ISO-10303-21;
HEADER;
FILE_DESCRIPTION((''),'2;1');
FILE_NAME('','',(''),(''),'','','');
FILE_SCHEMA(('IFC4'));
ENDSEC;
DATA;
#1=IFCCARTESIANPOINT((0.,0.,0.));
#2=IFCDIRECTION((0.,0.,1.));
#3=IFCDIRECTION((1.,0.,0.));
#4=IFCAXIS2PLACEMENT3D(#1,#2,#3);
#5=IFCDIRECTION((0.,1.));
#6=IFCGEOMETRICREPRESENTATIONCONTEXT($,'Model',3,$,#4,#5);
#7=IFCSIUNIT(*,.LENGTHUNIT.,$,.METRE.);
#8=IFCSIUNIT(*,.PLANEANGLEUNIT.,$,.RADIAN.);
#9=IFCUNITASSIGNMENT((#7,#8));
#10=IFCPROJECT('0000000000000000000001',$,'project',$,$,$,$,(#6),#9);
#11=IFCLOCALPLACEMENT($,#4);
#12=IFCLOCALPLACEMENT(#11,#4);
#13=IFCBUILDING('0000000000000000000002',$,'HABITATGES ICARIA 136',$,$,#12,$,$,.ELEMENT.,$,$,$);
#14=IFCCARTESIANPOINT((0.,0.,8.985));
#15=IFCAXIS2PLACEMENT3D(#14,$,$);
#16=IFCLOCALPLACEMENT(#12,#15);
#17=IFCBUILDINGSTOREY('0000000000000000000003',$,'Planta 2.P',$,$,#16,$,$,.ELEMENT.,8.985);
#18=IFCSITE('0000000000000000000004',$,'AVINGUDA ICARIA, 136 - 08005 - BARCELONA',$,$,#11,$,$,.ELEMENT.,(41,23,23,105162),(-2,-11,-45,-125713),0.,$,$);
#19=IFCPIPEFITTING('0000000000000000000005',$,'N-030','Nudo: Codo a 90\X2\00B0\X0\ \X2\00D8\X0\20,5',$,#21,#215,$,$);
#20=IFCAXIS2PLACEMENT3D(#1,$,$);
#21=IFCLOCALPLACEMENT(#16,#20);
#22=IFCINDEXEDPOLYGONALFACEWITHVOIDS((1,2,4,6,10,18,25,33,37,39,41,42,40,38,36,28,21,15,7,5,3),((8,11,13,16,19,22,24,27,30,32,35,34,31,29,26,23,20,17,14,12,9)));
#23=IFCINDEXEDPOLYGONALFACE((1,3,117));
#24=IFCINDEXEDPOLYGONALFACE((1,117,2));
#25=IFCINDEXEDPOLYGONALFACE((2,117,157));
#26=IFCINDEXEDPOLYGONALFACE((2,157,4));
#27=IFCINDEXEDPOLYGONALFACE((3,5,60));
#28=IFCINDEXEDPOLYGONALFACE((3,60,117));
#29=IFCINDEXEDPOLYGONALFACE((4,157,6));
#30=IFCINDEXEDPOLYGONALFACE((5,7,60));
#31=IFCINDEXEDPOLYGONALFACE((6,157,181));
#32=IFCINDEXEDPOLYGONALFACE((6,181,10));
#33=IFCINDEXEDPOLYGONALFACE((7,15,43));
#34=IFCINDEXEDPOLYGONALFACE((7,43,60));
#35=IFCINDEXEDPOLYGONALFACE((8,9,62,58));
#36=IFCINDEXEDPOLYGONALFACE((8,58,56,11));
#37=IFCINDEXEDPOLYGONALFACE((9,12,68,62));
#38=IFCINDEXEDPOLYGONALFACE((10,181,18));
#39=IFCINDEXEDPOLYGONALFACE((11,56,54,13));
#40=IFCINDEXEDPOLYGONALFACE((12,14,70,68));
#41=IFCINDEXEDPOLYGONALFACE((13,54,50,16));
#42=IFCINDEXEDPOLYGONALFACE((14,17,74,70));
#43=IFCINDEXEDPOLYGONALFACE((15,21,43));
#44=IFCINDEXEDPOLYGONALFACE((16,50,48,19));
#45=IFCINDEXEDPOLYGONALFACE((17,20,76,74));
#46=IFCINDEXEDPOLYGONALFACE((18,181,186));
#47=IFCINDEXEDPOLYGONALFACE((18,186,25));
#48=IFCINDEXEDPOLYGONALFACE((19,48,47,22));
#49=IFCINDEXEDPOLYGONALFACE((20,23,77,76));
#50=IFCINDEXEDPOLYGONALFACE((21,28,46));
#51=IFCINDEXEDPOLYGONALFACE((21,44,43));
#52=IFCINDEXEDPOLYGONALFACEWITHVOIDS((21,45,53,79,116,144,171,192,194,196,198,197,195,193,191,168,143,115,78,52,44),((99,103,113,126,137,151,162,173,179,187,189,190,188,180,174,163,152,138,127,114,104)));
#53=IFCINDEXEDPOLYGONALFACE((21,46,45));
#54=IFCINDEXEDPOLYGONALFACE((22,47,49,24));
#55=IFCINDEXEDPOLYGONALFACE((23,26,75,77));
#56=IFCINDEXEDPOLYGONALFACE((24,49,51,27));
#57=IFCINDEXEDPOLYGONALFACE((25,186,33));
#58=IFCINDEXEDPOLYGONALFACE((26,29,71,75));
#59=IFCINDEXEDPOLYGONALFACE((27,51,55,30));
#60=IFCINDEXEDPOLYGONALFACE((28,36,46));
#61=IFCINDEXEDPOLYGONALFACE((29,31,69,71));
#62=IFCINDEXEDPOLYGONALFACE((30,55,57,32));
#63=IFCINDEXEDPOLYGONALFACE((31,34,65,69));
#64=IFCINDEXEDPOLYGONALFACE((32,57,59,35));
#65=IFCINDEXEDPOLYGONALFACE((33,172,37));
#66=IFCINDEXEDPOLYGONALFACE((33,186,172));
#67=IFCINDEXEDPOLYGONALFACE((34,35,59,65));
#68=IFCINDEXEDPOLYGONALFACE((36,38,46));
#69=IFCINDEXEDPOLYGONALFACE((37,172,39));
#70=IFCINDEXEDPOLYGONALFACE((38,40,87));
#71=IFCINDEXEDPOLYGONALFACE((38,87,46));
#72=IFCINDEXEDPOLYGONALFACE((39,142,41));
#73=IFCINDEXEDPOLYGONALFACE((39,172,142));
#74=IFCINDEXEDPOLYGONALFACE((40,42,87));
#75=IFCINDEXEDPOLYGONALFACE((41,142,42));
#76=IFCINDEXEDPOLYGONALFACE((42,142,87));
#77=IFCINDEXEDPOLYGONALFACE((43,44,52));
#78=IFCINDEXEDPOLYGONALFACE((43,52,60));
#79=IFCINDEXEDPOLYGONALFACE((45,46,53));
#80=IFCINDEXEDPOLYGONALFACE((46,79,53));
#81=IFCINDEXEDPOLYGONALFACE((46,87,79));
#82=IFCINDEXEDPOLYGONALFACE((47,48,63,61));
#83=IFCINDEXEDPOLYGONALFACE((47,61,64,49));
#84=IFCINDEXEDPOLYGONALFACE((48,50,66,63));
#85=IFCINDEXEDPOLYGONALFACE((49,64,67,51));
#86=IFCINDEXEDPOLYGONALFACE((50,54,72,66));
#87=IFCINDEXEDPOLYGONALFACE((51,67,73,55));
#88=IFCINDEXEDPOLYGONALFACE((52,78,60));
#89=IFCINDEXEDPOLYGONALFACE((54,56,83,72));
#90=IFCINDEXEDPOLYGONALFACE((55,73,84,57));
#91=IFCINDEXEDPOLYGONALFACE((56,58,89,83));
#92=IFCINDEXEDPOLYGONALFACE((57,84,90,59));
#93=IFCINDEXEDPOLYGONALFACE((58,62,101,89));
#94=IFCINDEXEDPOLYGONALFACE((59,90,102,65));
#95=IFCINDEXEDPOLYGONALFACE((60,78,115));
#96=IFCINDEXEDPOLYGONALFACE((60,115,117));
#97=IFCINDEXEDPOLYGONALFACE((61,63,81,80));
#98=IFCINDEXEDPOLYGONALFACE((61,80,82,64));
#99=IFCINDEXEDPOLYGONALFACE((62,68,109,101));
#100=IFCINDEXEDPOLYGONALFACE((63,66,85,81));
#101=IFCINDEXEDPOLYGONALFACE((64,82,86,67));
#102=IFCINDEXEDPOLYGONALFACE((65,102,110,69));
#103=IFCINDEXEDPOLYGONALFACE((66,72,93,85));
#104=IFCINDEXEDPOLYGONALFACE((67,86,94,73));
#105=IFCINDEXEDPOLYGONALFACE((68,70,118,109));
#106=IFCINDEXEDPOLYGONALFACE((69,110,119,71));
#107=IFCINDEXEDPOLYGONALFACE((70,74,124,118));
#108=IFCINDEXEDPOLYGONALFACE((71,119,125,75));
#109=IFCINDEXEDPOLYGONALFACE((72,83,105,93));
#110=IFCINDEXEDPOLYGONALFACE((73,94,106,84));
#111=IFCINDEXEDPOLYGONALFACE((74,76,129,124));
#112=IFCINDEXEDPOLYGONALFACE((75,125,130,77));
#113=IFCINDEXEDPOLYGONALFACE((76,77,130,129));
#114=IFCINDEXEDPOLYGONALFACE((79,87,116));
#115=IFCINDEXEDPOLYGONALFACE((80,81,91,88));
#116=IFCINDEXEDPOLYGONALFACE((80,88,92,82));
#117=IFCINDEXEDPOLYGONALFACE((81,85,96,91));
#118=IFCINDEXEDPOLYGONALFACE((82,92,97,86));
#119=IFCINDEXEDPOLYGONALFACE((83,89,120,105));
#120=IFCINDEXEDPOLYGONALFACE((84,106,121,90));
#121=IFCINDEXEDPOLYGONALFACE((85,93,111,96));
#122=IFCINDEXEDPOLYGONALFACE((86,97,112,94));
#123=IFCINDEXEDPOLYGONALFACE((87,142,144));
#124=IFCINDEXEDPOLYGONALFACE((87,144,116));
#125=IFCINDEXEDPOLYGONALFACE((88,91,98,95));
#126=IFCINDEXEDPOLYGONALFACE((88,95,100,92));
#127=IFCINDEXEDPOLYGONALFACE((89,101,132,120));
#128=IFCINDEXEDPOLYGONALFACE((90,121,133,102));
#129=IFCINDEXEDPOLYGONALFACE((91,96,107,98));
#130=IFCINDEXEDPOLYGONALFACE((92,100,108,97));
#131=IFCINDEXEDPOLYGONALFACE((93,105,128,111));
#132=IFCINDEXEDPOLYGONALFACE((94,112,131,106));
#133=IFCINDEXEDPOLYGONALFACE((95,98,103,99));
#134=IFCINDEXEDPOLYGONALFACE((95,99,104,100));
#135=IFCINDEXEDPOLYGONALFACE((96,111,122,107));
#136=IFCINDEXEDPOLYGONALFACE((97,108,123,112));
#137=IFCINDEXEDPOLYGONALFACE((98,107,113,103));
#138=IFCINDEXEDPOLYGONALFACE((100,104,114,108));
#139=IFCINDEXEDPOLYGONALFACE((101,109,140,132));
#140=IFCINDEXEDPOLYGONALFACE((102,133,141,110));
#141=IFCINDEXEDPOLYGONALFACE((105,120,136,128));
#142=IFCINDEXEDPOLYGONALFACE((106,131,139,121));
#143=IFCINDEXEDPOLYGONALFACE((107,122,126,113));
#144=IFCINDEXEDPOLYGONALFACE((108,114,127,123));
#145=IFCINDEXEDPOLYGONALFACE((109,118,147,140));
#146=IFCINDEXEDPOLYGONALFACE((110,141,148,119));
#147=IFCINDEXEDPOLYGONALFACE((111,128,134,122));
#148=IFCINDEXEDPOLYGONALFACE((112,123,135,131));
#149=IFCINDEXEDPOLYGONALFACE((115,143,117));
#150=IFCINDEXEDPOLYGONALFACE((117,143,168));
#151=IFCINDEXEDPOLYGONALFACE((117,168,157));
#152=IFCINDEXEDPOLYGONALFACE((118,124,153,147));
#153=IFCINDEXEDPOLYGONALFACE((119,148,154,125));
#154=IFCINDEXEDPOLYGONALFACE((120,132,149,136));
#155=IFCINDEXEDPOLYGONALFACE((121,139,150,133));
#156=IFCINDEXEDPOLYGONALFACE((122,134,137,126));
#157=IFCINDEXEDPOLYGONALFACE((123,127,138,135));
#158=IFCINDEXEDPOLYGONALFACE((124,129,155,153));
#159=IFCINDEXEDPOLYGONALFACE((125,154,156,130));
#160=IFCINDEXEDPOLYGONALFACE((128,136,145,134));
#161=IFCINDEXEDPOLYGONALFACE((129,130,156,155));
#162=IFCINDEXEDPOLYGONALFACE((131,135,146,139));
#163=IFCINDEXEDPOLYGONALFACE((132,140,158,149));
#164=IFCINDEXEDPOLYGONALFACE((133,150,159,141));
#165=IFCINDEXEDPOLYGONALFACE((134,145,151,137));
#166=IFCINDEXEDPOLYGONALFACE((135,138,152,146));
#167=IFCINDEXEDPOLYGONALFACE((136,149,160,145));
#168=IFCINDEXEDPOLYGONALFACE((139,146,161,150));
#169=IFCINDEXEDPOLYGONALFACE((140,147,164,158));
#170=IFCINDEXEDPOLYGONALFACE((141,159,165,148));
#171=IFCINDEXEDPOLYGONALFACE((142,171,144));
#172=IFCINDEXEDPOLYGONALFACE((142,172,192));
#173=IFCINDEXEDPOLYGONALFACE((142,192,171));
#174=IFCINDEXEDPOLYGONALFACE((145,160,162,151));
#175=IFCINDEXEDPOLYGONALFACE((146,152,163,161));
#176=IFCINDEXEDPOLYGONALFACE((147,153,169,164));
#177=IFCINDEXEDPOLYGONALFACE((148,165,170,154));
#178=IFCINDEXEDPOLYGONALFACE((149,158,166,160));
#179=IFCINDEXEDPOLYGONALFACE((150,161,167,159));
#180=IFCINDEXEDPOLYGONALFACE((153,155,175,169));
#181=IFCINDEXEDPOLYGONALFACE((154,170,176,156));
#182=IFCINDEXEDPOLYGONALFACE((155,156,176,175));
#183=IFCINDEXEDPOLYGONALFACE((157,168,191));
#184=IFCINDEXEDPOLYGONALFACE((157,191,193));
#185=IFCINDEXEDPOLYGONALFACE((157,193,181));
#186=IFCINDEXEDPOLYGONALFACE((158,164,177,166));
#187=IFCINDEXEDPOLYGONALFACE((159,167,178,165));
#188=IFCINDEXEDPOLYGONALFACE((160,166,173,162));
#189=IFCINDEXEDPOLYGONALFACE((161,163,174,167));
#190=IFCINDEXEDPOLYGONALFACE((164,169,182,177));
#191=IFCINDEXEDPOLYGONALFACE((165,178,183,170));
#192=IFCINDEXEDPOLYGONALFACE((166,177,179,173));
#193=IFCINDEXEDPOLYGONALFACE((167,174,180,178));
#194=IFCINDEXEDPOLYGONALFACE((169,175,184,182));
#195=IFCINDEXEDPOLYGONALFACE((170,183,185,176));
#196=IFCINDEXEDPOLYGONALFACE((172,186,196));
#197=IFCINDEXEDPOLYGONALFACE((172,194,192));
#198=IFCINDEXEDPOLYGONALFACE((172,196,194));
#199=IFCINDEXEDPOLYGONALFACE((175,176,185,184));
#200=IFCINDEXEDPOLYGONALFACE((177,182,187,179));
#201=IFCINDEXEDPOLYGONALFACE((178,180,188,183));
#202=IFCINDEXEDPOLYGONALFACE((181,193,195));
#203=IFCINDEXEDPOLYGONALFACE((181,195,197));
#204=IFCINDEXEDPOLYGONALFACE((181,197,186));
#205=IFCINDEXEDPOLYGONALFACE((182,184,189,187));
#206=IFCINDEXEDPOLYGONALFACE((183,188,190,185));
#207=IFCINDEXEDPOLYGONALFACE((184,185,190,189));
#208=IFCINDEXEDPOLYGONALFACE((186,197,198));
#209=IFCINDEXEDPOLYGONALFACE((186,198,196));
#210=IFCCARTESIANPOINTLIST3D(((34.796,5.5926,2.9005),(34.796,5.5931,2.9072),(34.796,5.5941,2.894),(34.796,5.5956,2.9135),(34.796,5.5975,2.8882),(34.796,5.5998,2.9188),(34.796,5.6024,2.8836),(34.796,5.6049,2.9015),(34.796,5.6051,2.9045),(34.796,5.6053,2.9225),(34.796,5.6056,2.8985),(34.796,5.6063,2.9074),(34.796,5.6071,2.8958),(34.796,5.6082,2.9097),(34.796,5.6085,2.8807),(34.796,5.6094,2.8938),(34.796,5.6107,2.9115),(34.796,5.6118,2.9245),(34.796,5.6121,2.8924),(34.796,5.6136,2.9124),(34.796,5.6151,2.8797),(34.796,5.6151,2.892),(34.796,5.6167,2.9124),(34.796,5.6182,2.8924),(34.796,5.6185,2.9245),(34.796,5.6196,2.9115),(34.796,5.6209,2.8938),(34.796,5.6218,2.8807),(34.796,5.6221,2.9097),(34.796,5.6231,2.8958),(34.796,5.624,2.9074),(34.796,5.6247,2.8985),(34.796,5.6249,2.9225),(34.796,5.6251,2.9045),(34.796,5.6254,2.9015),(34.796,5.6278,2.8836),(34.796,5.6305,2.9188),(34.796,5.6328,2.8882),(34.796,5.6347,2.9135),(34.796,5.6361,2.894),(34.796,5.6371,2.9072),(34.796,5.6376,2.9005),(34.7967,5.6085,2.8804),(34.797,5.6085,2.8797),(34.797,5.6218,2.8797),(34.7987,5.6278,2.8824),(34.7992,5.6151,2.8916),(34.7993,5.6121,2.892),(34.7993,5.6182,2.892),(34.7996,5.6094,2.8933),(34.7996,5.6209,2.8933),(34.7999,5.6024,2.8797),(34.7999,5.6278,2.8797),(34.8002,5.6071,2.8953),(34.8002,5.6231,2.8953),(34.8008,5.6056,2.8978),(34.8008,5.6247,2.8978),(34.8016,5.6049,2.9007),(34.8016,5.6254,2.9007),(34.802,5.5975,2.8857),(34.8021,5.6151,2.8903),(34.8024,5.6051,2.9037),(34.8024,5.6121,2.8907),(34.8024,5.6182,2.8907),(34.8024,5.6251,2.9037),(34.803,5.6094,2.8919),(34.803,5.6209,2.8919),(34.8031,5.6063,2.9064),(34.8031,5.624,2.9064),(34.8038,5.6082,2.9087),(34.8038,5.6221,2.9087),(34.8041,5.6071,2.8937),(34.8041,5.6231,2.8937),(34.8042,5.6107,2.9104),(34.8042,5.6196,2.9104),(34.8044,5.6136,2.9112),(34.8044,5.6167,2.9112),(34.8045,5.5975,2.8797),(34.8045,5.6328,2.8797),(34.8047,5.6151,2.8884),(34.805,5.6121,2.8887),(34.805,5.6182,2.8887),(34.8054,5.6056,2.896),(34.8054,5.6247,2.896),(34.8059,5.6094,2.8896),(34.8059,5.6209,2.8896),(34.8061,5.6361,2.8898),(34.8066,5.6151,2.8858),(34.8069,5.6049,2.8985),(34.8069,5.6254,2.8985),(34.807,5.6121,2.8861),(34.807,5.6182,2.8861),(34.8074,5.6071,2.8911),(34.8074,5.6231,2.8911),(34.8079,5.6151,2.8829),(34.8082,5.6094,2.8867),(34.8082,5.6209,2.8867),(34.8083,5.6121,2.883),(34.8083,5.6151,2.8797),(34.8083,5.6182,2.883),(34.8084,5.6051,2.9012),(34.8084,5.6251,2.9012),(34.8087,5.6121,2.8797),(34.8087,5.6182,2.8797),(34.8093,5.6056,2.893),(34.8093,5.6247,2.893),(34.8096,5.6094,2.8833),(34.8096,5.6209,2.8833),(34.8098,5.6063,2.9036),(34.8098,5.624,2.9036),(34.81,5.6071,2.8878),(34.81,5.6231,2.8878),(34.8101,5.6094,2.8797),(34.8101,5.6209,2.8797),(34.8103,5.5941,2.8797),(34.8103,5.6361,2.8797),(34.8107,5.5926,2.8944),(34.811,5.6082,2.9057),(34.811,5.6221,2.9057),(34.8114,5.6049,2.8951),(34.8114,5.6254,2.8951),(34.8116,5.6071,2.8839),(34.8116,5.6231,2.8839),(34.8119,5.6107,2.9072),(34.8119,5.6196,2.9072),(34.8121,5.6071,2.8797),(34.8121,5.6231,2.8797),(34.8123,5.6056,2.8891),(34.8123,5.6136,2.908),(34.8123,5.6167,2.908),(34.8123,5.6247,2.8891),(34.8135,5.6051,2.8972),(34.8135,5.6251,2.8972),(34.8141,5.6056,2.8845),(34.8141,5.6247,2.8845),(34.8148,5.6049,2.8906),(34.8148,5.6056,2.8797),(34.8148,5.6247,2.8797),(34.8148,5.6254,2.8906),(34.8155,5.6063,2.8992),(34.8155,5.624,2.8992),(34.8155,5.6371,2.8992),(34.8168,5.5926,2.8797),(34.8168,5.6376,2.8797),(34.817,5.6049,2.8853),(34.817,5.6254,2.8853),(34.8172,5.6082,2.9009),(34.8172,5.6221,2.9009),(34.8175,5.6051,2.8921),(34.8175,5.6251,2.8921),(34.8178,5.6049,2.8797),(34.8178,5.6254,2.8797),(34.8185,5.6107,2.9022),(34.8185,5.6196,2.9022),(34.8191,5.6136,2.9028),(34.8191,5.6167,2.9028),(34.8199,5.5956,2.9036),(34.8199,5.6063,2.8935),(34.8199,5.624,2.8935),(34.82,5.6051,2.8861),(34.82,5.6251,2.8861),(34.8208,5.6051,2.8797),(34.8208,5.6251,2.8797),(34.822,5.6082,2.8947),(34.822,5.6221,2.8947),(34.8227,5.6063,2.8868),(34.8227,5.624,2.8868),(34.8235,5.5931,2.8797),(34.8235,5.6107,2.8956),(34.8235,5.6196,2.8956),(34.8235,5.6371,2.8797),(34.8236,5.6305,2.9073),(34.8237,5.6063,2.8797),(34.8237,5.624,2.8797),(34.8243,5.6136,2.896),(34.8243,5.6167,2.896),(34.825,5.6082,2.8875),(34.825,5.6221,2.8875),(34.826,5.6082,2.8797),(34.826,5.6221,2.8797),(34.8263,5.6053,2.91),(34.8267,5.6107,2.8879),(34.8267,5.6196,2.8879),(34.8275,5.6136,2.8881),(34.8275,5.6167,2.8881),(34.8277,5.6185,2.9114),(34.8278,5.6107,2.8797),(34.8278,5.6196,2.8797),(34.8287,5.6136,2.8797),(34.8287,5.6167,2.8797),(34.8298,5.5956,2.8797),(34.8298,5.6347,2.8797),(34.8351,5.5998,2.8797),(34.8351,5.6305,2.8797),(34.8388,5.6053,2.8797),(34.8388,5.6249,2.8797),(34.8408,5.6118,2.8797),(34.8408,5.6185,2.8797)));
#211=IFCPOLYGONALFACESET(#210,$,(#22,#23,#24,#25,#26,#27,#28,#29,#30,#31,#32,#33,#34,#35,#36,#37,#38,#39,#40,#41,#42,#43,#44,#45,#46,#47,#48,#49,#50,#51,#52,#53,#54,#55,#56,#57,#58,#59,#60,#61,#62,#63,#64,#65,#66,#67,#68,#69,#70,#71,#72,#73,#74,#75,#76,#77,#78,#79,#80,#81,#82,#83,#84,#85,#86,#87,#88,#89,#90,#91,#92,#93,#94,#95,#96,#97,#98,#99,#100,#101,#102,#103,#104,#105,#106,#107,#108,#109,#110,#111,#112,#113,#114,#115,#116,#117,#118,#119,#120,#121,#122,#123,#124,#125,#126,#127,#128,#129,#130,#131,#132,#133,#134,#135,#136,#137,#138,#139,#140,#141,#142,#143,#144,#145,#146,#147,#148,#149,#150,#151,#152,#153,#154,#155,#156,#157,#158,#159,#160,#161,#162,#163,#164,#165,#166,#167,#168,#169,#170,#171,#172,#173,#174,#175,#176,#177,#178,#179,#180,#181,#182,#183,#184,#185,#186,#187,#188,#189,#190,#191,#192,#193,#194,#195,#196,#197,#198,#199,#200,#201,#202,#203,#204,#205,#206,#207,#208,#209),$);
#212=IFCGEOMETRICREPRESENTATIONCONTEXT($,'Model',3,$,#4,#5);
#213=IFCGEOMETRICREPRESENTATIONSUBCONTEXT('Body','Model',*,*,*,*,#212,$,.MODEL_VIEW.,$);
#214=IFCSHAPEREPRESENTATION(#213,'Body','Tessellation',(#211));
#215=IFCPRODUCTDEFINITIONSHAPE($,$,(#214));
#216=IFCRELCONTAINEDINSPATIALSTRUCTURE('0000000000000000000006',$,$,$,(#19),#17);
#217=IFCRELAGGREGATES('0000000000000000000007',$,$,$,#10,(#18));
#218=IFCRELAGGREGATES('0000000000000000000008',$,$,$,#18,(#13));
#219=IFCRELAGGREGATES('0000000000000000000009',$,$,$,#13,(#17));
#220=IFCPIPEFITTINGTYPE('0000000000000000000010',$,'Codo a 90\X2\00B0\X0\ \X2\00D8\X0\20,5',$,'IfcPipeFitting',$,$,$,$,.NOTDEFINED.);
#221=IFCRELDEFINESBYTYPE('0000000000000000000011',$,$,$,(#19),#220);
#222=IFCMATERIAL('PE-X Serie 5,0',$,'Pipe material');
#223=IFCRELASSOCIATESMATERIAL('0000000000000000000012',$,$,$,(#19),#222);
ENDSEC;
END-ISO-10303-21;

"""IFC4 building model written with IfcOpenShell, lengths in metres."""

from ifc_helpers import new_model, entity, si_unit, direction, frame, origin_with_axes, place, context, subcontext, project, spatial, source, transform, mapped, material, type_object, element, save


model = new_model("IFC4")

# Units and contexts
model_context_1 = context("Model", 3, world=origin_with_axes(), true_north=direction((0.0, 1.0)))
model_context_2 = context("Model", 3, world=origin_with_axes(), true_north=direction((0.0, 1.0)))
body_context_1 = subcontext(model_context_2, "Body", "Model", "MODEL_VIEW")
ifc_project = project(units=[si_unit("LENGTHUNIT", "METRE"), si_unit("PLANEANGLEUNIT", "RADIAN")], contexts=[model_context_1])

# Site, building, storey
site_placement = place(None, origin_with_axes())
site = spatial("IfcSite", under=ifc_project, at=site_placement, Name="AVINGUDA ICARIA, 136 - 08005 - BARCELONA", CompositionType="ELEMENT", RefLatitude=(41, 23, 23, 105162), RefLongitude=(-2, -11, -45, -125713), RefElevation=0.0)
building_placement = place(site_placement, origin_with_axes())
building = spatial("IfcBuilding", under=site, at=building_placement, Name="HABITATGES ICARIA 136", CompositionType="ELEMENT")
storey_placement = place(building_placement, frame((0.0, 0.0, 8.985)))
storey = spatial("IfcBuildingStorey", under=building, at=storey_placement, Name="Planta 2.P", CompositionType="ELEMENT", Elevation=8.985)

# Shared definitions
ifc_material_1 = material(Name="PE-X Serie 5,0", Category="Pipe material")
placement_1 = place(None, origin_with_axes())
placement_2 = place(placement_1, origin_with_axes())
placement_3 = place(placement_2, frame((0.0, 0.0, 8.985)))

# Pipe fitting
pipe_fitting_type_1 = type_object("IfcPipeFittingType", Name="Codo a 90° Ø20,5", ApplicableOccurrence="IfcPipeFitting", PredefinedType="NOTDEFINED")
shared_shape_1 = source(origin_with_axes(), body_context_1, "Body", "SweptSolid", [
    entity("IfcRevolvedAreaSolid", entity("IfcCircleHollowProfileDef", "AREA", None, entity("IfcAxis2Placement2D", entity("IfcCartesianPoint", [0.0, 0.0]), entity("IfcDirection", [1.0, 0.0])), 0.0226, 0.0123), entity("IfcAxis2Placement3D", entity("IfcCartesianPoint", [0.0226, 0.0, 0.0]), entity("IfcDirection", [-1.0, 0.0, 0.0]), entity("IfcDirection", [0.0, -1.0, 0.0])), entity("IfcAxis1Placement", entity("IfcCartesianPoint", [0.0226, 0.0, 0.0]), entity("IfcDirection", [0.0, 1.0, 0.0])), 1.570796),
])
pipe_fitting_1_placement = place(placement_3, origin_with_axes())
element("IfcPipeFitting", 1, at=pipe_fitting_1_placement, inside=storey, type_object=pipe_fitting_type_1, material=ifc_material_1, Name="N-030", Description="Nudo: Codo a 90° Ø20,5", context=body_context_1, shape_type="MappedRepresentation", body=[
    mapped(shared_shape_1, transform((34.8185, 5.6151, 2.9022), x_axis=(-1.0, 0.0, 0.0), y_axis=(0.0, 0.0, 1.0), z_axis=(0.0, 1.0, 0.0), scale=1.0)),
])

save(model, "model.ifc")
